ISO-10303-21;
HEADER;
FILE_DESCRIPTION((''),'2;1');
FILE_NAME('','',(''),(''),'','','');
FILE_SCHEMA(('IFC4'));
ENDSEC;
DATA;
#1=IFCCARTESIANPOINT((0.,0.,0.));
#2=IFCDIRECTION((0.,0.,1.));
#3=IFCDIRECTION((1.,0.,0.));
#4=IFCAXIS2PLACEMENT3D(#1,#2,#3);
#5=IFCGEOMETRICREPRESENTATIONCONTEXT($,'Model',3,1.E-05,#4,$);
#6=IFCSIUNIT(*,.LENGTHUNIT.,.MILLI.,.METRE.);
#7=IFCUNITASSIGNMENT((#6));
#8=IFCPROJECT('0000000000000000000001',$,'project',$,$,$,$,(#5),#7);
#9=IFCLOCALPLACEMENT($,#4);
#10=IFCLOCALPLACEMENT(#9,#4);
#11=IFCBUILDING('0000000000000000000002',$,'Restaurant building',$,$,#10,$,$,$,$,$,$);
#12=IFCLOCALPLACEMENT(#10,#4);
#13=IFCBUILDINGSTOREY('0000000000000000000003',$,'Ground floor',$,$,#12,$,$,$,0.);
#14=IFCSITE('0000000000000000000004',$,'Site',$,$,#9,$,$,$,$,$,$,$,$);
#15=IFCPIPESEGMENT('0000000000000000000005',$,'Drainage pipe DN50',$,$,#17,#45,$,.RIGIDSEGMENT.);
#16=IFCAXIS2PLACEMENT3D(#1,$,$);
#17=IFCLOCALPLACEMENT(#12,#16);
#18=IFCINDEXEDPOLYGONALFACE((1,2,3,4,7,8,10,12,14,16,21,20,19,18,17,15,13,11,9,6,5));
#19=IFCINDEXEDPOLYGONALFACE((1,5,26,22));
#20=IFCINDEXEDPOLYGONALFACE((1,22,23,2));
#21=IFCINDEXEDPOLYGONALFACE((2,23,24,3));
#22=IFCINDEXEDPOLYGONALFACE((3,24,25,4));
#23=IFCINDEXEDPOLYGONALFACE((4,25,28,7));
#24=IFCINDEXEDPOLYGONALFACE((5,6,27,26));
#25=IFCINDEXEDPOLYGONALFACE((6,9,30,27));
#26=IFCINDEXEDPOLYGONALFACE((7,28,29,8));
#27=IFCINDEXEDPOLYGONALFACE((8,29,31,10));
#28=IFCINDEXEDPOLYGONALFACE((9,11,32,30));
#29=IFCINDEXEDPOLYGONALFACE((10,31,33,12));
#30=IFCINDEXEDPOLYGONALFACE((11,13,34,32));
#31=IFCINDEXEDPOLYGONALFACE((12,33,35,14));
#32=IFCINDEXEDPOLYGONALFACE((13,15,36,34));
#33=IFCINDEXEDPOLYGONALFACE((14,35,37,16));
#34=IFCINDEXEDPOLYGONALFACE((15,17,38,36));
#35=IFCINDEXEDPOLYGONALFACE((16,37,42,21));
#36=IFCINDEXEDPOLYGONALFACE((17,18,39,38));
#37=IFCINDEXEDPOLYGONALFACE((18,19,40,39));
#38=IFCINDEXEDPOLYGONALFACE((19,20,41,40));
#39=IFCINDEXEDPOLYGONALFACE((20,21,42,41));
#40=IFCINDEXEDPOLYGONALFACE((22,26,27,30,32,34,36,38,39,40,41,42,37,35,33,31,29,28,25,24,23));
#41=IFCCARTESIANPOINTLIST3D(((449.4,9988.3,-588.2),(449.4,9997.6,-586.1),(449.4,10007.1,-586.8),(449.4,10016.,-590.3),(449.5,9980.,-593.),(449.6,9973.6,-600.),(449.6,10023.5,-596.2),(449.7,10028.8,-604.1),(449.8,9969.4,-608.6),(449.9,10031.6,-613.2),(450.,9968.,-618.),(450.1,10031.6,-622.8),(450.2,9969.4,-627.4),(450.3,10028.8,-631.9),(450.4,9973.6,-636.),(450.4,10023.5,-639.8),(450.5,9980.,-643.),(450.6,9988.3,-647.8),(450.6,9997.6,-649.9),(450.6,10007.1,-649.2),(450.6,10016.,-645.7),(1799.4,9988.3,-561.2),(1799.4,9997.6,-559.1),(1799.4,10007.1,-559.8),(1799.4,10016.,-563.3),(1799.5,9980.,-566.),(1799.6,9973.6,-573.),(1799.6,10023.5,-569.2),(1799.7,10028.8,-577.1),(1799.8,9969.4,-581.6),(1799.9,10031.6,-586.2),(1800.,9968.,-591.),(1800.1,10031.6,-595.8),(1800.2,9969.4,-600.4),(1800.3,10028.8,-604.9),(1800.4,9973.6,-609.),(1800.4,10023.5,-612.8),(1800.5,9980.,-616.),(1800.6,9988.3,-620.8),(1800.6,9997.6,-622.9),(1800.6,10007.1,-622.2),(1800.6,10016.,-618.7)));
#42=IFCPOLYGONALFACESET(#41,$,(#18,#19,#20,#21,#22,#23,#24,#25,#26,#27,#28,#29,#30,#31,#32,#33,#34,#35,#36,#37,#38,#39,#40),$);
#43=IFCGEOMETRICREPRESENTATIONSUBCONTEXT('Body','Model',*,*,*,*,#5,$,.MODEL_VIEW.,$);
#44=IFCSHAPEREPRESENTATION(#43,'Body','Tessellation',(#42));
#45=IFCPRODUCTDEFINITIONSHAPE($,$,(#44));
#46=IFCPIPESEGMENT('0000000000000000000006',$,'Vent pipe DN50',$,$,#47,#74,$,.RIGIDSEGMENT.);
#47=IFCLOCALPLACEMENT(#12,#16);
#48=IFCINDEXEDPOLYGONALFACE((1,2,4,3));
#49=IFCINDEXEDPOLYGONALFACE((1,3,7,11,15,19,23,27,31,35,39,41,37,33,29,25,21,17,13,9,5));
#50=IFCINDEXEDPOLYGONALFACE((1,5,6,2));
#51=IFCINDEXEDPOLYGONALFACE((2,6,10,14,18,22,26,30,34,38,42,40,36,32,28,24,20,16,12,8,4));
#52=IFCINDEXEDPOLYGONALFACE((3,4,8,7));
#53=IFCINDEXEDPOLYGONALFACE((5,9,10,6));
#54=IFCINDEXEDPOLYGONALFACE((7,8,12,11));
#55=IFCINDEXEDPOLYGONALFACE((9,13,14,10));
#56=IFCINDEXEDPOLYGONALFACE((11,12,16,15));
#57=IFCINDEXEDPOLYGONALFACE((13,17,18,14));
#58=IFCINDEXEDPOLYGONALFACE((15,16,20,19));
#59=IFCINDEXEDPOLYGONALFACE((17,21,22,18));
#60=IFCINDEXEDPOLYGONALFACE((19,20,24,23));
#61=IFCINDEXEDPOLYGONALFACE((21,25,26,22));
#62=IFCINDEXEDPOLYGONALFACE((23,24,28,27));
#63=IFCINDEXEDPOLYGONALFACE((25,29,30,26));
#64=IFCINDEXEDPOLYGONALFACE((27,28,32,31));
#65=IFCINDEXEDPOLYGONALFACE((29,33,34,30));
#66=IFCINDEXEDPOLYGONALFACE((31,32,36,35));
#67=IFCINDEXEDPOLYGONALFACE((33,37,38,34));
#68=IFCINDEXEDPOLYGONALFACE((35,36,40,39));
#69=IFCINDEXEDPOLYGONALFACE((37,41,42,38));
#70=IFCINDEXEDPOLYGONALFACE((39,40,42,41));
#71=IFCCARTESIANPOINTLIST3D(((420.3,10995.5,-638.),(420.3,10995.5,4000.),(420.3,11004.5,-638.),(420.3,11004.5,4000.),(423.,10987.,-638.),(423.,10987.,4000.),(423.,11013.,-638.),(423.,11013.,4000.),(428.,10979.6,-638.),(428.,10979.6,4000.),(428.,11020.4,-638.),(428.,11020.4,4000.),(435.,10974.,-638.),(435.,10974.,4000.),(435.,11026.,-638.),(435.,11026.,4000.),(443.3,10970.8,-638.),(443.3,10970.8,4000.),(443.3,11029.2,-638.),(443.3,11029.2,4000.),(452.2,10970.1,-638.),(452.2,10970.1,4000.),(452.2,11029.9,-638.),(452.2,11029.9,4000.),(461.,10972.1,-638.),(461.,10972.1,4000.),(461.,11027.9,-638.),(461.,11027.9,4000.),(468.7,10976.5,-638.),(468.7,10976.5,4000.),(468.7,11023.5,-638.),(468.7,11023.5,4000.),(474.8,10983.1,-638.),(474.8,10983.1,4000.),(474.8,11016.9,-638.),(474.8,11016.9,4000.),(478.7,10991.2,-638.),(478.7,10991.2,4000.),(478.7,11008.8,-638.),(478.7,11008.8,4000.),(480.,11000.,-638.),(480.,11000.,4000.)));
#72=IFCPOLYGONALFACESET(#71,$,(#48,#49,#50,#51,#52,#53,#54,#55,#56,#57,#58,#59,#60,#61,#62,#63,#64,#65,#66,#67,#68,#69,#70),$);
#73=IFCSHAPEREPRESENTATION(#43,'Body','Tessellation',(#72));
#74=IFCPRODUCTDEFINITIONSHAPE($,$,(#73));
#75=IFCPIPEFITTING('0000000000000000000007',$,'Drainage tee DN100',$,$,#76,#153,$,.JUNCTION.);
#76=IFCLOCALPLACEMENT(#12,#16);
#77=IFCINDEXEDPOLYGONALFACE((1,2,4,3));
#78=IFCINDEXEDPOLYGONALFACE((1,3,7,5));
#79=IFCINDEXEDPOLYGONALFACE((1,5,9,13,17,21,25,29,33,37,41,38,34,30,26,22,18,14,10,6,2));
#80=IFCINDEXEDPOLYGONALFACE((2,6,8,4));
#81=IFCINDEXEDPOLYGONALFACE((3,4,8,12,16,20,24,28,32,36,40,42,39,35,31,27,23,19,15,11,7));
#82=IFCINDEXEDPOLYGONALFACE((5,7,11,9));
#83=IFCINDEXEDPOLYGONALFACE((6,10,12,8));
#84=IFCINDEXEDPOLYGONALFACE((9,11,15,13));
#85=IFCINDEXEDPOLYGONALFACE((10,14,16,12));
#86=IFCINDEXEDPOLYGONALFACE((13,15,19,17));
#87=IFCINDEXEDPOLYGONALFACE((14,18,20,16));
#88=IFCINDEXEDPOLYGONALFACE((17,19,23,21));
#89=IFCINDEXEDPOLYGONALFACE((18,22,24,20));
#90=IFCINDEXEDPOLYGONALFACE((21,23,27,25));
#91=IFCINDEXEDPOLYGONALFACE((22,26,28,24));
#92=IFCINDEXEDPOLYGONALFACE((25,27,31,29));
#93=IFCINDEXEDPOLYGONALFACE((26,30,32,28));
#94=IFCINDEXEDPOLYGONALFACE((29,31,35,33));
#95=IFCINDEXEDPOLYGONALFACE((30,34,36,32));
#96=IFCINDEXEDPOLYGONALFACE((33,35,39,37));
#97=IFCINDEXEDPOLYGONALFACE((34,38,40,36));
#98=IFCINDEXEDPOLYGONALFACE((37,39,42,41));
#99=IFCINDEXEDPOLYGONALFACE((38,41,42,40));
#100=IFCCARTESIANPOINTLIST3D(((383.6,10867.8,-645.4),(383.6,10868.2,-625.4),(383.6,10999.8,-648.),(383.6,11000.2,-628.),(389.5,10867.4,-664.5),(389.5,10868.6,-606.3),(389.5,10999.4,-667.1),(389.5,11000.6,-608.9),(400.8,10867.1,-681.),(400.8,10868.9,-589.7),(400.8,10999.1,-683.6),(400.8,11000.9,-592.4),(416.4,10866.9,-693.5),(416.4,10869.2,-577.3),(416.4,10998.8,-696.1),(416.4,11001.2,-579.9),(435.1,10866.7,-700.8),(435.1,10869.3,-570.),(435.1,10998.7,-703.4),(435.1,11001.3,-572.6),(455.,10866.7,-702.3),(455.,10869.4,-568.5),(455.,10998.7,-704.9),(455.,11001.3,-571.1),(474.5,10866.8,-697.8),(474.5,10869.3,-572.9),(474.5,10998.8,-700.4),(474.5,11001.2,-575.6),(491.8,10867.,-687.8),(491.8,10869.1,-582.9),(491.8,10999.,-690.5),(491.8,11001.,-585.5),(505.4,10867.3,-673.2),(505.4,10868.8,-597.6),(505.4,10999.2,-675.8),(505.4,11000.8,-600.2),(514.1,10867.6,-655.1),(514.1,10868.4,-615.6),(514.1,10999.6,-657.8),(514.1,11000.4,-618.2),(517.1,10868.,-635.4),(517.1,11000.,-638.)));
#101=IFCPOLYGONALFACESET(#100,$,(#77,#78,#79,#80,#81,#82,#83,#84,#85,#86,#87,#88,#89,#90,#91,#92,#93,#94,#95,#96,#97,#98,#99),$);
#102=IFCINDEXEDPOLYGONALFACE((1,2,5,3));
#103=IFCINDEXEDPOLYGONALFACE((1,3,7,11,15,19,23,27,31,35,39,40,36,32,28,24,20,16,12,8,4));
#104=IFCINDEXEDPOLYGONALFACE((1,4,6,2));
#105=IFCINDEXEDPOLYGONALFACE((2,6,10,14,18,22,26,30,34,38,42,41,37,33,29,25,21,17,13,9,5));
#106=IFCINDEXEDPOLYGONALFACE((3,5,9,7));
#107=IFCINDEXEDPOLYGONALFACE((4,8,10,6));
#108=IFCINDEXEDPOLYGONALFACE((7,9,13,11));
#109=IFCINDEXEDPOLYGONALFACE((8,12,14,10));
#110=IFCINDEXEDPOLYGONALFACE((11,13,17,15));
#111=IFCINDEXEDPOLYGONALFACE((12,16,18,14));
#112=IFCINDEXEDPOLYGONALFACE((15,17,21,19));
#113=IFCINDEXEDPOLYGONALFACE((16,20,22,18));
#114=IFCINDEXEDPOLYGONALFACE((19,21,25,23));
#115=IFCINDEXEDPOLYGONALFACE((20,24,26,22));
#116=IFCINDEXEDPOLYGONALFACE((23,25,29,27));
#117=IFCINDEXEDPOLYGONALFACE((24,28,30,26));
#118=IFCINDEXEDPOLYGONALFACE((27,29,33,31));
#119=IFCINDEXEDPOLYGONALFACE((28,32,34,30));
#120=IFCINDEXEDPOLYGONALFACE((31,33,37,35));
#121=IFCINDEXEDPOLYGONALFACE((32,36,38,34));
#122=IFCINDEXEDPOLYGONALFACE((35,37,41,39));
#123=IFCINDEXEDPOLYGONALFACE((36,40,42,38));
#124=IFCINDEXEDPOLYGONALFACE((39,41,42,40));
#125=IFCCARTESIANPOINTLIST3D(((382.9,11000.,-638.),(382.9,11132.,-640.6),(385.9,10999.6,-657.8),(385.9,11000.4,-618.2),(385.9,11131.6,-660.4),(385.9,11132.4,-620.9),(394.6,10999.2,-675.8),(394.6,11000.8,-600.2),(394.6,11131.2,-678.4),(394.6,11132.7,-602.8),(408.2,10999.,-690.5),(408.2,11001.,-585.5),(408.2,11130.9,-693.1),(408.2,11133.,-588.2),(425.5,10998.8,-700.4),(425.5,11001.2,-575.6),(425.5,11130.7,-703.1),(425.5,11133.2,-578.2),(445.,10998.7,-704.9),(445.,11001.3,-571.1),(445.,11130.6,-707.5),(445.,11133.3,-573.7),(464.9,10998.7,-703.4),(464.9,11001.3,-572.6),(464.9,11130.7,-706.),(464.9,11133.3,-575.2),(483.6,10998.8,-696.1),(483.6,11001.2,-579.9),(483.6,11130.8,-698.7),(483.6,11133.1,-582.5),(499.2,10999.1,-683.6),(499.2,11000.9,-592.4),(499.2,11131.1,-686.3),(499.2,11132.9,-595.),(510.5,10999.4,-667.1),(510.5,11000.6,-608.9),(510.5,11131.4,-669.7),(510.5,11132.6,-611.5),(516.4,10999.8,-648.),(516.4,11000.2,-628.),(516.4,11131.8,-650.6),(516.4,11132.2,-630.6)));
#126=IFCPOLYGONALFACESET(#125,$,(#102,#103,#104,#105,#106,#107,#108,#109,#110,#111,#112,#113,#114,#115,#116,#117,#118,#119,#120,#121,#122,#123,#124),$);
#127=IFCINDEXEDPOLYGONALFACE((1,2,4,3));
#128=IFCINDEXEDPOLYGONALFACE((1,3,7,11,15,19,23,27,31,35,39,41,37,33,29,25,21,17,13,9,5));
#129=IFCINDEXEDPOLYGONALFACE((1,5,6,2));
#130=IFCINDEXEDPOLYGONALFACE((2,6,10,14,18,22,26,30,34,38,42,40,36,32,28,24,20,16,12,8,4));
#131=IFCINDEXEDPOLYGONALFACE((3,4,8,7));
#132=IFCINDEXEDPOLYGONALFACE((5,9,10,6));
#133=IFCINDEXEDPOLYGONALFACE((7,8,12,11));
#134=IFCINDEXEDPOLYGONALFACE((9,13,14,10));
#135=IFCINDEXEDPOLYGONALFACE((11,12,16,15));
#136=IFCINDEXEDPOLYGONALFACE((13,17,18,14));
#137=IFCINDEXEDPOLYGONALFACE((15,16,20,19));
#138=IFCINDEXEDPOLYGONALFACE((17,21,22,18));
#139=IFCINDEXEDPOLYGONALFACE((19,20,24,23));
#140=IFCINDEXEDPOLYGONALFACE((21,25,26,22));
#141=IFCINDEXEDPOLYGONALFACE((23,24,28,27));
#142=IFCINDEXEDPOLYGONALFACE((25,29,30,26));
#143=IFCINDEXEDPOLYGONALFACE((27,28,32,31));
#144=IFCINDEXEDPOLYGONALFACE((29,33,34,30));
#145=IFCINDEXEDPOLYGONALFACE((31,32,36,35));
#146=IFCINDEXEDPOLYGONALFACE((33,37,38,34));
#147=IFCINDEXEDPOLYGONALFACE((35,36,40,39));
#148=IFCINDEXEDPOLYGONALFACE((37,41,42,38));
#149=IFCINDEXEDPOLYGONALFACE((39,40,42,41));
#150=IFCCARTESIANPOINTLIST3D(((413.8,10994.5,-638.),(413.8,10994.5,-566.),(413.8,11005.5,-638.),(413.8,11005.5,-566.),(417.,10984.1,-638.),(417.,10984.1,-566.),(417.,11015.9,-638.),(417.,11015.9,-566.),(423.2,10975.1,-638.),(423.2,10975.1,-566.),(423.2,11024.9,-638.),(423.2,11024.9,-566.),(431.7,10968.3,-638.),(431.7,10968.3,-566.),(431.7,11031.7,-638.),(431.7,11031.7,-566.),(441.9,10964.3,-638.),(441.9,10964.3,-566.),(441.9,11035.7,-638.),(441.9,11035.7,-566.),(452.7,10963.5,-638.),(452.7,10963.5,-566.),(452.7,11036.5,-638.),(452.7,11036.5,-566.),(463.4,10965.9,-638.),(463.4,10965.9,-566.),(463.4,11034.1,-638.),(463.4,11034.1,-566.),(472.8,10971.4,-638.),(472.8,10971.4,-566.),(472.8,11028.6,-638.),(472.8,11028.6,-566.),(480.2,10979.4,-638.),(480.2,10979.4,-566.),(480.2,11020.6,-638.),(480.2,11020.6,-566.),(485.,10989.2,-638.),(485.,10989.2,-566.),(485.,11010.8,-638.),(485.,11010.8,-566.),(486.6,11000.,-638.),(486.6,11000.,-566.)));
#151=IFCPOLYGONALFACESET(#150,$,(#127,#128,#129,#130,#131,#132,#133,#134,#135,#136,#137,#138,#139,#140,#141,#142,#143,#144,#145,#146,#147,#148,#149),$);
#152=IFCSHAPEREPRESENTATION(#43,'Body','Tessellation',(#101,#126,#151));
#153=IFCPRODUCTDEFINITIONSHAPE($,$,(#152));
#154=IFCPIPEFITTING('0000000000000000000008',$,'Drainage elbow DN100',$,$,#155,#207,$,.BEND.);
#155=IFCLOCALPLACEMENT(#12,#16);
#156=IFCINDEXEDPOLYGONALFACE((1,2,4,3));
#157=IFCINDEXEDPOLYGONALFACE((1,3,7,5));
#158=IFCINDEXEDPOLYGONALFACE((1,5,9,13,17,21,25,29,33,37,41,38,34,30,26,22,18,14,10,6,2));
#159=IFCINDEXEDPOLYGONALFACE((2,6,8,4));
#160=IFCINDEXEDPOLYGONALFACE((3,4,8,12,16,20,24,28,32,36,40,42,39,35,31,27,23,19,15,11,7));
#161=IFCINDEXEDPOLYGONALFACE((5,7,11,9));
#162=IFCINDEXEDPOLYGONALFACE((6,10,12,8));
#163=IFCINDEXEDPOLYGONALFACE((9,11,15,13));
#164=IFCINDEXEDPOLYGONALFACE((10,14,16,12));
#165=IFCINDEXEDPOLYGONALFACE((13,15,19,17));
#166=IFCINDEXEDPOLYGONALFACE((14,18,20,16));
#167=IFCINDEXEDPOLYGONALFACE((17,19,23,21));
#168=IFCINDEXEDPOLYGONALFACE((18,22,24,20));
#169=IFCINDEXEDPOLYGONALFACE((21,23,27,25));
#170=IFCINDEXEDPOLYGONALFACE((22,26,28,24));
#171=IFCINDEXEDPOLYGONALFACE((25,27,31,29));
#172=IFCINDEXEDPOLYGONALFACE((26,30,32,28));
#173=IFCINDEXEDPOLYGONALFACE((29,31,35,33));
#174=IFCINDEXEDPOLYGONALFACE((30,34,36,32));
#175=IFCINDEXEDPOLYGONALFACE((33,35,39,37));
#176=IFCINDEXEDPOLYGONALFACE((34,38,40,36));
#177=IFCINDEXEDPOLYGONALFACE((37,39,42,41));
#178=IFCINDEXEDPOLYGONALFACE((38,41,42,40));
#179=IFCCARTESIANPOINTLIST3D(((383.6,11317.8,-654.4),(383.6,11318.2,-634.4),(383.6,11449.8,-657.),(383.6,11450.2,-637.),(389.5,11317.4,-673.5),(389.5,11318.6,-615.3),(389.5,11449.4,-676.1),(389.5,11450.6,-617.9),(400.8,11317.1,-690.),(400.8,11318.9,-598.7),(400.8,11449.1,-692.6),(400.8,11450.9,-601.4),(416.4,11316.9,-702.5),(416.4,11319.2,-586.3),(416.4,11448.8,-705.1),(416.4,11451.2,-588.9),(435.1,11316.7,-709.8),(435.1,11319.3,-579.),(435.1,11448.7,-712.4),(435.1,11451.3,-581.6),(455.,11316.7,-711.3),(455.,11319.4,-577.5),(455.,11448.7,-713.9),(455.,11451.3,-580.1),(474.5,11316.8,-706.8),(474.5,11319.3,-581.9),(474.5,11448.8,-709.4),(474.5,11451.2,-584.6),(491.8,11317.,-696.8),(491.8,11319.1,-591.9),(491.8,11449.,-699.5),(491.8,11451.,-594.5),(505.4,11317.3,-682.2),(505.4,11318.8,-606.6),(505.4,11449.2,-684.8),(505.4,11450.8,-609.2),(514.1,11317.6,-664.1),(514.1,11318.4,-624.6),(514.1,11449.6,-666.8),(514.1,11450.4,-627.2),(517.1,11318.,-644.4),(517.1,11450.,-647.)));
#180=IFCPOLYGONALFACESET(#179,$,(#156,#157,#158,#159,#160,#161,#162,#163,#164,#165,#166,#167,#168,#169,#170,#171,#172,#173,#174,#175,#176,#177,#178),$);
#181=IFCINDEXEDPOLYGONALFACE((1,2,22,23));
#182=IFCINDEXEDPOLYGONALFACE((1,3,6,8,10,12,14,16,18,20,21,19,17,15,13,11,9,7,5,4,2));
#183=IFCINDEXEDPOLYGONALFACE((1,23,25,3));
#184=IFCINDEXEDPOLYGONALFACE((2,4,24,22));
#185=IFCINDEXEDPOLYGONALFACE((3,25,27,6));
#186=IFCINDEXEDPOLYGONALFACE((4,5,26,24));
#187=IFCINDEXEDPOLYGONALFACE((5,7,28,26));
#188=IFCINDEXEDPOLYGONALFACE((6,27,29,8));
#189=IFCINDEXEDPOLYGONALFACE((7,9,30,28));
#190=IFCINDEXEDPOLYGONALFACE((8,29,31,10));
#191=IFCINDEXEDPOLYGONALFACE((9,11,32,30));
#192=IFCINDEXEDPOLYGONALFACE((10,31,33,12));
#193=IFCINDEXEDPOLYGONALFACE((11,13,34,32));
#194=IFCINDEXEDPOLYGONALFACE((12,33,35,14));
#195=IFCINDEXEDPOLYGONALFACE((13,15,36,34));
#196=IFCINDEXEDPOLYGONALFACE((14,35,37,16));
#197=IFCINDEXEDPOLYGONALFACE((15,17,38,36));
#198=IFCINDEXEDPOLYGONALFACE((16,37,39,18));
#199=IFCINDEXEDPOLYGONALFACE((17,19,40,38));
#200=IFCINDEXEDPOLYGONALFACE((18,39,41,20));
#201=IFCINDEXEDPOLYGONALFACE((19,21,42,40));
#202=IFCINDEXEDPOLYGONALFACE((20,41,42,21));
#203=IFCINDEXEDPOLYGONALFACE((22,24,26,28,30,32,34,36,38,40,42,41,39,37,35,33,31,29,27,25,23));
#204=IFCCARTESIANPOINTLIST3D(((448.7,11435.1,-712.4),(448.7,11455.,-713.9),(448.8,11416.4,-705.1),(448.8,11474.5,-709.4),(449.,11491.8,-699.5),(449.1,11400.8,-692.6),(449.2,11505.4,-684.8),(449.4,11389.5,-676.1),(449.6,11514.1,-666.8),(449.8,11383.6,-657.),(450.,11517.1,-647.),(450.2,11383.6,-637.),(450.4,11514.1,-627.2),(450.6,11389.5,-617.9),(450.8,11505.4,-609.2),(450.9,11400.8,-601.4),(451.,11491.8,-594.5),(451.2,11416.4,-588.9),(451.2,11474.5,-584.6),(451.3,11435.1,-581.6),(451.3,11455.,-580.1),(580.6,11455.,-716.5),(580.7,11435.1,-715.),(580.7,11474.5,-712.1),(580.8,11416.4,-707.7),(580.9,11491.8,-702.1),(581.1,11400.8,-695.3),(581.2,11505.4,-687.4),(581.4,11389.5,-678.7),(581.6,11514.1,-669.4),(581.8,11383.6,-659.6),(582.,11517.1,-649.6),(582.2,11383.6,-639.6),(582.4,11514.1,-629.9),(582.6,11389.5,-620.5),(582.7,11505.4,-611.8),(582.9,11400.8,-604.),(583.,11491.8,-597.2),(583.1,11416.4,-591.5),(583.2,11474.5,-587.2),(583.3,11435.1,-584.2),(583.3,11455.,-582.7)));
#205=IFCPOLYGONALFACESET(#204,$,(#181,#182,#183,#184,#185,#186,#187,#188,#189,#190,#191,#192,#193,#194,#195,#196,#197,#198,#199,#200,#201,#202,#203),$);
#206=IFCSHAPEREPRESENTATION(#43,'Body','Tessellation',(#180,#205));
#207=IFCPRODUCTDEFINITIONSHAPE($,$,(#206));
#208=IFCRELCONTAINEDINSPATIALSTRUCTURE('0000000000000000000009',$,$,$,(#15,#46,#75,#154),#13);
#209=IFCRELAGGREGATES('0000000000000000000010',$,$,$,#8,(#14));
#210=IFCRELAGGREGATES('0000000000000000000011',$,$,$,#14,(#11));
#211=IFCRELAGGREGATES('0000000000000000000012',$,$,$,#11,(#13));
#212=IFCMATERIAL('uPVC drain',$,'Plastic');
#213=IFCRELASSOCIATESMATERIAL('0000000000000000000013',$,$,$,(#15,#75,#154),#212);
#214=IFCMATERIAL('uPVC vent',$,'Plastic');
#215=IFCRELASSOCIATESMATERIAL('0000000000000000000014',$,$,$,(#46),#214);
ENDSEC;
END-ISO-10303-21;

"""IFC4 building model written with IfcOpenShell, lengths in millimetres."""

from ifc_helpers import new_model, si_unit, frame, origin, origin_with_axes, origin_2d, place, context, subcontext, project, spatial, circle, extrude, material, element, save


model = new_model("IFC4")

# Units and contexts
model_context = context("Model", 3, precision=1e-05, world=origin_with_axes())
body_context = subcontext(model_context, "Body", "Model", "MODEL_VIEW")
ifc_project = project(units=[si_unit("LENGTHUNIT", "METRE", prefix="MILLI")], contexts=[model_context])

# Site, building, storey
site_placement = place(None, origin_with_axes())
site = spatial("IfcSite", under=ifc_project, at=site_placement, Name="Site")
building_placement = place(site_placement, origin_with_axes())
building = spatial("IfcBuilding", under=site, at=building_placement, Name="Restaurant building")
storey_placement = place(building_placement, origin_with_axes())
storey = spatial("IfcBuildingStorey", under=building, at=storey_placement, Name="Ground floor", Elevation=0.0)

# Shared definitions
ifc_material_1 = material(Name="uPVC drain", Category="Plastic")

# Shared definitions
ifc_material_2 = material(Name="uPVC vent", Category="Plastic")

# Pipe segments
pipe_segment_1_placement = place(storey_placement, frame((1800.0, 10000.0, -591.0)))
element("IfcPipeSegment", 1, at=pipe_segment_1_placement, inside=storey, material=ifc_material_1, Name="Drainage pipe DN50", PredefinedType="RIGIDSEGMENT", context=body_context, shape_type="SweptSolid", body=[
    extrude(circle(Radius=32.0, at=origin_2d()), frame((0.0, 0.0, 0.0), z_axis=(-0.9998, 0.0, -0.019996), x_axis=(0.0, -1.0, 0.0)), (0.0, 0.0, 1.0), 1350.3),
])
pipe_segment_2_placement = place(storey_placement, frame((450.0, 11000.0, -638.0)))
element("IfcPipeSegment", 2, at=pipe_segment_2_placement, inside=storey, material=ifc_material_2, Name="Vent pipe DN50", PredefinedType="RIGIDSEGMENT", context=body_context, shape_type="SweptSolid", body=[
    extrude(circle(Radius=30.0, at=origin_2d()), origin(), (0.0, 0.0, 1.0), 4638.0),
])

# Pipe fittings
pipe_fitting_1_placement = place(storey_placement, frame((450.0, 11000.0, -638.0)))
element("IfcPipeFitting", 3, at=pipe_fitting_1_placement, inside=storey, material=ifc_material_1, Name="Drainage tee DN100", PredefinedType="JUNCTION", context=body_context, shape_type="SweptSolid", body=[
    extrude(circle(Radius=67.1, at=origin_2d()), frame((0.0, 0.0, 0.0), z_axis=(0.0, -0.9998, 0.019996), x_axis=(1.0, 0.0, 0.0)), (0.0, 0.0, 1.0), 132.0),
    extrude(circle(Radius=67.1, at=origin_2d()), frame((0.0, 0.0, 0.0), z_axis=(0.0, 0.9998, -0.019996), x_axis=(-1.0, 0.0, 0.0)), (0.0, 0.0, 1.0), 132.0),
    extrude(circle(Radius=36.6, at=origin_2d()), origin(), (0.0, 0.0, 1.0), 72.0),
])
pipe_fitting_2_placement = place(storey_placement, frame((450.0, 11450.0, -647.0)))
element("IfcPipeFitting", 4, at=pipe_fitting_2_placement, inside=storey, material=ifc_material_1, Name="Drainage elbow DN100", PredefinedType="BEND", context=body_context, shape_type="SweptSolid", body=[
    extrude(circle(Radius=67.1, at=origin_2d()), frame((0.0, 0.0, 0.0), z_axis=(0.0, -0.9998, 0.019996), x_axis=(1.0, 0.0, 0.0)), (0.0, 0.0, 1.0), 132.0),
    extrude(circle(Radius=67.1, at=origin_2d()), frame((0.0, 0.0, 0.0), z_axis=(0.9998, 0.0, -0.019996), x_axis=(0.0, 1.0, 0.0)), (0.0, 0.0, 1.0), 132.0),
])

save(model, "model.ifc")
